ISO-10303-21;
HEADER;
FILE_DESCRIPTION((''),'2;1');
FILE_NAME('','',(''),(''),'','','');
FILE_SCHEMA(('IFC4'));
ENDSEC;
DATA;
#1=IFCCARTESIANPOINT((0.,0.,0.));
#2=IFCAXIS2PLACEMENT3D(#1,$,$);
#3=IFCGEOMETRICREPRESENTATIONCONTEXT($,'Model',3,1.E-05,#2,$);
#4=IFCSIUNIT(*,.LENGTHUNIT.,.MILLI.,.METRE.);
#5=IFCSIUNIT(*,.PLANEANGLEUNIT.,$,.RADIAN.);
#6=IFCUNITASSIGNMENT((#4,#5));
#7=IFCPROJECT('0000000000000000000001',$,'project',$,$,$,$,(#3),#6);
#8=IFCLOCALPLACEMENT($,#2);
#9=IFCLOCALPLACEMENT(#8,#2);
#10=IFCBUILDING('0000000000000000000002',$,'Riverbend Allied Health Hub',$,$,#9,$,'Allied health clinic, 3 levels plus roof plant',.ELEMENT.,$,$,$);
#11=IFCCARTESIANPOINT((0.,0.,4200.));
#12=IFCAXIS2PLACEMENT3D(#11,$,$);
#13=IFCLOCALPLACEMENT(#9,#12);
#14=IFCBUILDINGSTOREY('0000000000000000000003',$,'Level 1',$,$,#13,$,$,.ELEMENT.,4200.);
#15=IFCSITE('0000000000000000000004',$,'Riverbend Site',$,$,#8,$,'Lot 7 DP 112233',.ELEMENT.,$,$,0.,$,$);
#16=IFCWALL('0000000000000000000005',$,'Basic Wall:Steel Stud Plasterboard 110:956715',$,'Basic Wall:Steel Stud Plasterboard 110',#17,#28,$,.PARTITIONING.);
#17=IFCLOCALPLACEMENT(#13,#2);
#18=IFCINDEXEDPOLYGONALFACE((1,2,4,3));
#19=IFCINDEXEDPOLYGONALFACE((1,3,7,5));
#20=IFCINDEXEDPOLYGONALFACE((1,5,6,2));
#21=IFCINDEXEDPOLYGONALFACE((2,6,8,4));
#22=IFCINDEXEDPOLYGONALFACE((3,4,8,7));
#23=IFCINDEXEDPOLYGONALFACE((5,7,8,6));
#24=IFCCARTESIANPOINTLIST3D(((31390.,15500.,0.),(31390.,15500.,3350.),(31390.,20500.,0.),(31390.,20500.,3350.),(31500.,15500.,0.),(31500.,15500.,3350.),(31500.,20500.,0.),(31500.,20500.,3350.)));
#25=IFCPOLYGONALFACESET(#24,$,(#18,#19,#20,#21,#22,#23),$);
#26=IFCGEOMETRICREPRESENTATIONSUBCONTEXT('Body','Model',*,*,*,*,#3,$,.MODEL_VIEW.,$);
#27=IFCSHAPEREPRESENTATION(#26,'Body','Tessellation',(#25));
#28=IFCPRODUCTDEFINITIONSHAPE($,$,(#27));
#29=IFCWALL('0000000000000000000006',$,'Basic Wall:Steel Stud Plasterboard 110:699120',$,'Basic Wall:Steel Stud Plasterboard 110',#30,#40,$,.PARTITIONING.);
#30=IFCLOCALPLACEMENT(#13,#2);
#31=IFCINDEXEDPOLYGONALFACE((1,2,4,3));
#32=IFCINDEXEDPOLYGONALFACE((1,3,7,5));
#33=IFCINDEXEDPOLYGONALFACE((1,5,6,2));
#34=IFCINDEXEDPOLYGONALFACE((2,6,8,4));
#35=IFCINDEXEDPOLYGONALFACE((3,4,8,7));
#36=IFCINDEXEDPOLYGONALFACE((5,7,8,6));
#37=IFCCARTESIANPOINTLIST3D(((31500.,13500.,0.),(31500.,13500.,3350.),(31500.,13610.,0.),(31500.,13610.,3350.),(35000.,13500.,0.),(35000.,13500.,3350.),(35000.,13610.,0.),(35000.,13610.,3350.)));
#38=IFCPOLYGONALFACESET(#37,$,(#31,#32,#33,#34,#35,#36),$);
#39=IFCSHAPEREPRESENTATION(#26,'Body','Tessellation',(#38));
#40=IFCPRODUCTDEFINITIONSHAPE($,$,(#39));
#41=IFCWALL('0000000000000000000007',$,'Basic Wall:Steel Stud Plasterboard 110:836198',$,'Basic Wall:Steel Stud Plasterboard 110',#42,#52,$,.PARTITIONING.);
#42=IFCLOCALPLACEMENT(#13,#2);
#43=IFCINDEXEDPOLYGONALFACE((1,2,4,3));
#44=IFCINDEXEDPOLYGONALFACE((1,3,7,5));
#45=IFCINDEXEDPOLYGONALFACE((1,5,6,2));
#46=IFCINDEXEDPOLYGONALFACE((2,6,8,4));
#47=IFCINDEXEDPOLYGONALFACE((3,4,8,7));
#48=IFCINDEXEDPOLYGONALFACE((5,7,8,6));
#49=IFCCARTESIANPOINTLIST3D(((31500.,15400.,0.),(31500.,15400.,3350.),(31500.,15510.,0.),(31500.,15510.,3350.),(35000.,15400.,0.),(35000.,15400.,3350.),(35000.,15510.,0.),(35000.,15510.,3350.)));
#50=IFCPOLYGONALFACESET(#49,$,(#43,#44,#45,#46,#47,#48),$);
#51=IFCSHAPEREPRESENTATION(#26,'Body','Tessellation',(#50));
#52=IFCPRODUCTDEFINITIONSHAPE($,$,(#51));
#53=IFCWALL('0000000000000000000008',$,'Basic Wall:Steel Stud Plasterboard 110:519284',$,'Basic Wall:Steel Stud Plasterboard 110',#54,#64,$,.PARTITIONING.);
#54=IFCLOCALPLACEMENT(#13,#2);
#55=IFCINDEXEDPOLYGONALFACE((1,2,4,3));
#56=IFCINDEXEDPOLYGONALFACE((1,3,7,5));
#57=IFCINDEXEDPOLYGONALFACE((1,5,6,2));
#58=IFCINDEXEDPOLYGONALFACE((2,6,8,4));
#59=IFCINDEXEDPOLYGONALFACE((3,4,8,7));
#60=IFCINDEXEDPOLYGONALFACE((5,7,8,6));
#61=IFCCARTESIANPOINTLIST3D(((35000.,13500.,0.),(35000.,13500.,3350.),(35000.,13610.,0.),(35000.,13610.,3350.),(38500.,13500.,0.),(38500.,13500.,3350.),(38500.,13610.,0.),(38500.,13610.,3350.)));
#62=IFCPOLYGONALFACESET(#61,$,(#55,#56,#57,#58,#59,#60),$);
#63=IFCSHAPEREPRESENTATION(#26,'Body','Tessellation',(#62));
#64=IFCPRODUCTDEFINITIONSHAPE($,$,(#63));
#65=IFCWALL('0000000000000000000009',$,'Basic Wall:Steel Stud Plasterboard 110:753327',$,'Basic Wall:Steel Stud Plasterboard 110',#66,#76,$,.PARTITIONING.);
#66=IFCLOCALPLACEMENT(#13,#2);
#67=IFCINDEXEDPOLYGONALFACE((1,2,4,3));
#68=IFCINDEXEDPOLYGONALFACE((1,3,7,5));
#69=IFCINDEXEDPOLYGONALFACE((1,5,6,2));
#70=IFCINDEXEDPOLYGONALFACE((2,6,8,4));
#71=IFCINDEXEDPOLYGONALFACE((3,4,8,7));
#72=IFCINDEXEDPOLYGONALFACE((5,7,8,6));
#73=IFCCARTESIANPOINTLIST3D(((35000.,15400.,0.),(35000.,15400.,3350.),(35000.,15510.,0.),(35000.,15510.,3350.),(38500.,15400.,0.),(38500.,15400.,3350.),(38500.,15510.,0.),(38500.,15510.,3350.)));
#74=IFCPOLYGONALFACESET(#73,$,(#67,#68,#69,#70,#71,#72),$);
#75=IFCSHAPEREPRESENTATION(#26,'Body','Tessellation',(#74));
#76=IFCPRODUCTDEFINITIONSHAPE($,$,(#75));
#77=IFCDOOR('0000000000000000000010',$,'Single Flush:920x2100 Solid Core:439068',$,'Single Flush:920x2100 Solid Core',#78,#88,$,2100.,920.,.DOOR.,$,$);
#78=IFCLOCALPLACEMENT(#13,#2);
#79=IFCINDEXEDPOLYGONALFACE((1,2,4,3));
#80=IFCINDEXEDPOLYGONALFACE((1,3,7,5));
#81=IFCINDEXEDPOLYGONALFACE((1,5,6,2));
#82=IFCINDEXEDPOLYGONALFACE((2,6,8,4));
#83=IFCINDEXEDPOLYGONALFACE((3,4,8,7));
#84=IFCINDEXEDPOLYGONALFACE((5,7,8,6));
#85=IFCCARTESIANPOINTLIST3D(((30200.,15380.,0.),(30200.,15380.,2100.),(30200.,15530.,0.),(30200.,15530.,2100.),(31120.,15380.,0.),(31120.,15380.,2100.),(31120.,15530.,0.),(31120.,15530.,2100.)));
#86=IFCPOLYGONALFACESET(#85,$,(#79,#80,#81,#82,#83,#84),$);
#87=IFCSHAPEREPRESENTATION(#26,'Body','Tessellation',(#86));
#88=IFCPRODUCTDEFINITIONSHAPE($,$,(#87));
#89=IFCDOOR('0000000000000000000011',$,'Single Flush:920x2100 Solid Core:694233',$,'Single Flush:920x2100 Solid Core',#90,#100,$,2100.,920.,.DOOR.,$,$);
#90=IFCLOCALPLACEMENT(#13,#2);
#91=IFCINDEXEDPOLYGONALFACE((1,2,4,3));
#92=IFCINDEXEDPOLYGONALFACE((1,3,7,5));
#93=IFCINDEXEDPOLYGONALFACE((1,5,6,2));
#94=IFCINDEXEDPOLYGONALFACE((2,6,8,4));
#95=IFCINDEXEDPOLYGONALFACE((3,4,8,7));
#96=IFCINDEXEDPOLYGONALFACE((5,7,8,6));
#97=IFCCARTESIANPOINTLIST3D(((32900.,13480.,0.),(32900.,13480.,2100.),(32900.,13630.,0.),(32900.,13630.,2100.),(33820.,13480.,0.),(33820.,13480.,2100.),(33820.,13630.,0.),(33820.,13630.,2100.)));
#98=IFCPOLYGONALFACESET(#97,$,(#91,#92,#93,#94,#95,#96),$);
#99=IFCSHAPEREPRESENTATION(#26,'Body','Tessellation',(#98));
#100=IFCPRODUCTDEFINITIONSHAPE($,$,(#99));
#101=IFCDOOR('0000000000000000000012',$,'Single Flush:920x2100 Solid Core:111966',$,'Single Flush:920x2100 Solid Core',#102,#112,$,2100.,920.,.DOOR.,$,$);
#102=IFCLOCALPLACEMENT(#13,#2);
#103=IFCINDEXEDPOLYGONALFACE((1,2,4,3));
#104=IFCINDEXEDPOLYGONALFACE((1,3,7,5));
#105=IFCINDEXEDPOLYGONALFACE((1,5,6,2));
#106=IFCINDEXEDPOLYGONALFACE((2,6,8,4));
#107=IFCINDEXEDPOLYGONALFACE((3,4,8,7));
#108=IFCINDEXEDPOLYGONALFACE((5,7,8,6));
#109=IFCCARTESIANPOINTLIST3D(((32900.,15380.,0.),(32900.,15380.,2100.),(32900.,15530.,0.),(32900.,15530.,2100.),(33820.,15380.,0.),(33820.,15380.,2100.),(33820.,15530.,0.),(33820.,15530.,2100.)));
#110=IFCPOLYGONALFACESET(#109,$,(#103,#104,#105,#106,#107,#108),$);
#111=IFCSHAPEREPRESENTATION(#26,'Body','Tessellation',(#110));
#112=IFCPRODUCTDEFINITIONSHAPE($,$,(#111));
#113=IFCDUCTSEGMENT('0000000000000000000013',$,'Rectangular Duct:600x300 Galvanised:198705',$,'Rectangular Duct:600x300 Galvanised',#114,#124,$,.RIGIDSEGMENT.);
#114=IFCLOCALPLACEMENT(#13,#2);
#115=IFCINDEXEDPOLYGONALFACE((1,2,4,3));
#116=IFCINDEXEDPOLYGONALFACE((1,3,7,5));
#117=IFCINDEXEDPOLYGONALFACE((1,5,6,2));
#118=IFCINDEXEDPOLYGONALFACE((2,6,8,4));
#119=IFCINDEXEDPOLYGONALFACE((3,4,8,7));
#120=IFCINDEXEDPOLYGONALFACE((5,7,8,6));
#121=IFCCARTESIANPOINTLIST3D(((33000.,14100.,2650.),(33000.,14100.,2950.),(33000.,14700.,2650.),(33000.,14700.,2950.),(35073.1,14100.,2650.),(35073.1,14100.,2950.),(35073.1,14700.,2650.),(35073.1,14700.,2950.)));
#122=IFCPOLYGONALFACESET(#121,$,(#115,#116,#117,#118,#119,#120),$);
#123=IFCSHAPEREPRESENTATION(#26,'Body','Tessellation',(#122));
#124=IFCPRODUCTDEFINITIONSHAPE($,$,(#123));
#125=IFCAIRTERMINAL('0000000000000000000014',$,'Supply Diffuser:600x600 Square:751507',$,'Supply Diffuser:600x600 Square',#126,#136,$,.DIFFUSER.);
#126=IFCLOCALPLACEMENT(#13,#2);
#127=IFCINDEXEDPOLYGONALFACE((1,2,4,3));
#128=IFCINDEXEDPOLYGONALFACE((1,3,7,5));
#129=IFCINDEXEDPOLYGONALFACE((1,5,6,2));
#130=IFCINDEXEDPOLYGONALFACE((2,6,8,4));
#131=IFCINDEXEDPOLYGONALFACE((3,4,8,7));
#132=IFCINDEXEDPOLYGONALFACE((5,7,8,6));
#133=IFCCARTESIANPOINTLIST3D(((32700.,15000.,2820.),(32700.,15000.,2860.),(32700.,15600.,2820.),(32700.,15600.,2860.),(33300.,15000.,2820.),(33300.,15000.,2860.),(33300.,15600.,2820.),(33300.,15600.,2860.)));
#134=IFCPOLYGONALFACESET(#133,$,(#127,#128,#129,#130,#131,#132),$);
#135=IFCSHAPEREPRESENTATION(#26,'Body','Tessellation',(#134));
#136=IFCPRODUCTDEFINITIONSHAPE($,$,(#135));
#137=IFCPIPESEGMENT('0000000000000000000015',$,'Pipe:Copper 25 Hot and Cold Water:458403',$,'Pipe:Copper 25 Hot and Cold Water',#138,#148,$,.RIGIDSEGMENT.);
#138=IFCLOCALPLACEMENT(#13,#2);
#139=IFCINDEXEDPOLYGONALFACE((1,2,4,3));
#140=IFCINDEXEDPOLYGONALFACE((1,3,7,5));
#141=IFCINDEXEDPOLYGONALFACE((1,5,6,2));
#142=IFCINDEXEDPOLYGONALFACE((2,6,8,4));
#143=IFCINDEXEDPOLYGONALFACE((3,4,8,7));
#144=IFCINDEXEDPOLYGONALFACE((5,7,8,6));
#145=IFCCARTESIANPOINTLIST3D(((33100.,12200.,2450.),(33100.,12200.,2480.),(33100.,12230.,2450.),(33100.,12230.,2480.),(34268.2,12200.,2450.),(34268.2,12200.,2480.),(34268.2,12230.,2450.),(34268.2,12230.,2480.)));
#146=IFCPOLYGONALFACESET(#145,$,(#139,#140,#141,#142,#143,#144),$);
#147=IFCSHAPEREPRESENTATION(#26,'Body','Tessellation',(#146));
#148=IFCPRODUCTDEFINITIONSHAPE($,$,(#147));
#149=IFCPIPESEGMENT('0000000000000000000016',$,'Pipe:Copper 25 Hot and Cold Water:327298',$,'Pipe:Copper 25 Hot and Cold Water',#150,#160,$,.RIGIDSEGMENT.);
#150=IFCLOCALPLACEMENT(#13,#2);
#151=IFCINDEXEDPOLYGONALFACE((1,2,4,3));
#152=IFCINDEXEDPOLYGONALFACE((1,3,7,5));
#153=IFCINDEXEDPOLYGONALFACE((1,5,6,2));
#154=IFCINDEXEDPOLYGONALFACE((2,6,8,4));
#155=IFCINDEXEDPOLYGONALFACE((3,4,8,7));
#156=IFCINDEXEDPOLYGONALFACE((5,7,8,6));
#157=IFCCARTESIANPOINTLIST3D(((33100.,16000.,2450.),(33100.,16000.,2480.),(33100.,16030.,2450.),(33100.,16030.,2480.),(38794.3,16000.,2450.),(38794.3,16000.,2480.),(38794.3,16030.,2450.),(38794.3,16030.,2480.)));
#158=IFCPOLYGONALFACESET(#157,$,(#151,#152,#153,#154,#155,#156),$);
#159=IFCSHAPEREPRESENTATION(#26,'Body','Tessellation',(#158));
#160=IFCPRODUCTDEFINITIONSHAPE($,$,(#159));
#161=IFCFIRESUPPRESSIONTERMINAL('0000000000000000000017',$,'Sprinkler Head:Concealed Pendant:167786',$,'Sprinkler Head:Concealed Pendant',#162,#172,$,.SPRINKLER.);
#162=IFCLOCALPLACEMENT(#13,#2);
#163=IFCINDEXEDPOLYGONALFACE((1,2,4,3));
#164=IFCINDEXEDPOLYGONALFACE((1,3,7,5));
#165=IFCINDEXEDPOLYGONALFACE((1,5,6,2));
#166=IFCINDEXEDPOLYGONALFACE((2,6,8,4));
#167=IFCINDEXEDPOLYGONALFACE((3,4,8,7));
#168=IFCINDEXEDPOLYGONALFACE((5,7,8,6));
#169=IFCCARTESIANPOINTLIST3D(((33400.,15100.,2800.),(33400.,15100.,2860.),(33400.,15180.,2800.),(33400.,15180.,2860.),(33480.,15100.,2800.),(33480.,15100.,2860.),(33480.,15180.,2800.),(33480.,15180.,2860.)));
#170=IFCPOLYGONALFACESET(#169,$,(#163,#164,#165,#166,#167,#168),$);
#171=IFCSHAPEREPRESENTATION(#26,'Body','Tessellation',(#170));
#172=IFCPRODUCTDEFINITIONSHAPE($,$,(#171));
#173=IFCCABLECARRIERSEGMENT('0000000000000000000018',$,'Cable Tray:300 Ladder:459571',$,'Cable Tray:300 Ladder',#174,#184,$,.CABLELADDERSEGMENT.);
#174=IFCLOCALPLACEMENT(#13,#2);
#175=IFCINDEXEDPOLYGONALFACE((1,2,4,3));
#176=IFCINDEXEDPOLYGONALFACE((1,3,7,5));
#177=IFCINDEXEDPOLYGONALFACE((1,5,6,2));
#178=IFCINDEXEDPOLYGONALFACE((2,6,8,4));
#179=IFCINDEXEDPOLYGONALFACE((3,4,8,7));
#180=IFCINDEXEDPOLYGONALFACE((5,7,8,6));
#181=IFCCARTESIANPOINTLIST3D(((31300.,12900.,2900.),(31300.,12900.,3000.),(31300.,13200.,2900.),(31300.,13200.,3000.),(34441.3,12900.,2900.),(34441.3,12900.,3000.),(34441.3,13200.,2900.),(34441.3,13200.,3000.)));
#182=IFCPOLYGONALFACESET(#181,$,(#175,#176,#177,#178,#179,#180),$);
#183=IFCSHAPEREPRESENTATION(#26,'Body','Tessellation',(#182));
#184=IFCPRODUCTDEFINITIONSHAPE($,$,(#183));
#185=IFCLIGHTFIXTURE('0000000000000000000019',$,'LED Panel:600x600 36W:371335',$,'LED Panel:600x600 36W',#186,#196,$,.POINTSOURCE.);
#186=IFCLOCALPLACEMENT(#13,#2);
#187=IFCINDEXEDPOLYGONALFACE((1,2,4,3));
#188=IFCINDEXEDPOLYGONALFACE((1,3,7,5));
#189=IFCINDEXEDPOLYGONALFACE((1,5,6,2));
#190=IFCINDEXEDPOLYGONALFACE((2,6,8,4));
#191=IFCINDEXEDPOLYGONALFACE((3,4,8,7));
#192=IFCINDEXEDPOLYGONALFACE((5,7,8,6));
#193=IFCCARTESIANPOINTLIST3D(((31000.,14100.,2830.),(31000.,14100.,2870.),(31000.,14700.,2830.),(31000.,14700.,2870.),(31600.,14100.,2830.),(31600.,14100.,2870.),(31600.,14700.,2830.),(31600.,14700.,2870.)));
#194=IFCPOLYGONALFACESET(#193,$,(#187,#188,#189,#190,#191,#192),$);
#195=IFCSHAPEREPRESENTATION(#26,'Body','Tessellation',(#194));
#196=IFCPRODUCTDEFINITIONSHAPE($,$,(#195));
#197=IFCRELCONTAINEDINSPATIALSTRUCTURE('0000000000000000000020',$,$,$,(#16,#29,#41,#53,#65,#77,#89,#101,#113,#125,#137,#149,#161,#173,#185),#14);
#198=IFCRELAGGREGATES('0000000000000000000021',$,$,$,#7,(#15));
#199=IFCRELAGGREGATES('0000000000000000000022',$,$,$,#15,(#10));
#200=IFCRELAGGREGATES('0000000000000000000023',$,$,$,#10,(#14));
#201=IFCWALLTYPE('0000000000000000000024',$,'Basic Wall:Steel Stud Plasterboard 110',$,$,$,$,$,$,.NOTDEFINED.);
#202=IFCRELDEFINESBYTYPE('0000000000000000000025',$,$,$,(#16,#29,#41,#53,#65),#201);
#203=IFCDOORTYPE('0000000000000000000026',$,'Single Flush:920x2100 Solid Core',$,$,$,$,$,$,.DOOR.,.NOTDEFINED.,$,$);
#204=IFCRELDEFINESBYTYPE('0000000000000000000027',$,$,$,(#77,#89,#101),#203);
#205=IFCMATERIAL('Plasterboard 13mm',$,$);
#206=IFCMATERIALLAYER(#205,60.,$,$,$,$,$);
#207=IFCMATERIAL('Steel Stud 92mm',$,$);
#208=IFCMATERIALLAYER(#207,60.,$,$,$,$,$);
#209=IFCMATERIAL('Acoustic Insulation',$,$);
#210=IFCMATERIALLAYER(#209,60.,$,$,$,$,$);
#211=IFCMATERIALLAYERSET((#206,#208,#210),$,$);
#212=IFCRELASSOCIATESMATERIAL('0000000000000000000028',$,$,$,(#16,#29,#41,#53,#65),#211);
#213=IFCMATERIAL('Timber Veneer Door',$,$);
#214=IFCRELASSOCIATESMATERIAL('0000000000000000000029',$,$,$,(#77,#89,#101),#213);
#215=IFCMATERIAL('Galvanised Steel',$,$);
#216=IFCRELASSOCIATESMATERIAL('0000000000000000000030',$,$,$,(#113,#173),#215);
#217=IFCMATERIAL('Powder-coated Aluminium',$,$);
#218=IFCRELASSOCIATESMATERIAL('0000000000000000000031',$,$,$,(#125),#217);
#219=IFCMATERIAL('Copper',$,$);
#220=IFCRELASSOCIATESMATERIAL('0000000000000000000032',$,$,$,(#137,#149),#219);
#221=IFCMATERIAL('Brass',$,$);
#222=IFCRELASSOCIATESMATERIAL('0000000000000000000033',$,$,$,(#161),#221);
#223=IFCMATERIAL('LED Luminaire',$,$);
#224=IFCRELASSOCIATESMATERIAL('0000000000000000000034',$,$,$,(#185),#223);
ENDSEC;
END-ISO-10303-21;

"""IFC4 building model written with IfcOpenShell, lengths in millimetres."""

from ifc_helpers import new_model, si_unit, frame, frame_2d, origin, place, context, subcontext, project, spatial, rectangle, extrude, material, layer, layer_set, layer_usage, type_object, element, save


model = new_model("IFC4")

# Units and contexts
model_context = context("Model", 3, precision=1e-05, world=origin())
body_context = subcontext(model_context, "Body", "Model", "MODEL_VIEW")
ifc_project = project(units=[si_unit("LENGTHUNIT", "METRE", prefix="MILLI"), si_unit("PLANEANGLEUNIT", "RADIAN")], contexts=[model_context])

# Site, building, storey
site_placement = place(None, origin())
site = spatial("IfcSite", under=ifc_project, at=site_placement, Name="Riverbend Site", LongName="Lot 7 DP 112233", CompositionType="ELEMENT", RefElevation=0.0)
building_placement = place(site_placement, origin())
building = spatial("IfcBuilding", under=site, at=building_placement, Name="Riverbend Allied Health Hub", LongName="Allied health clinic, 3 levels plus roof plant", CompositionType="ELEMENT")
storey_placement = place(building_placement, frame((0.0, 0.0, 4200.0)))
storey = spatial("IfcBuildingStorey", under=building, at=storey_placement, Name="Level 1", CompositionType="ELEMENT", Elevation=4200.0)

# Walls
ifc_material_1 = material(Name="Plasterboard 13mm")
ifc_layer_1 = layer(ifc_material_1, 60.0)
ifc_material_2 = material(Name="Steel Stud 92mm")
ifc_layer_2 = layer(ifc_material_2, 60.0)
ifc_material_3 = material(Name="Acoustic Insulation")
ifc_layer_3 = layer(ifc_material_3, 60.0)
ifc_layer_set = layer_set([ifc_layer_1, ifc_layer_2, ifc_layer_3])
ifc_layer_usage = layer_usage(ifc_layer_set, "AXIS2", "POSITIVE", 0.0)
wall_type = type_object("IfcWallType", Name="Basic Wall:Steel Stud Plasterboard 110", PredefinedType="NOTDEFINED")
wall_placement = place(storey_placement, frame((31500.0, 15500.0, 0.0), z_axis=(0.0, 0.0, 1.0), x_axis=(0.0, 1.0, 0.0)))
element("IfcWall", 1, at=wall_placement, inside=storey, type_object=wall_type, material=ifc_layer_usage, Name="Basic Wall:Steel Stud Plasterboard 110:956715", ObjectType="Basic Wall:Steel Stud Plasterboard 110", PredefinedType="PARTITIONING", context=body_context, shape_type="SweptSolid", body=[
    extrude(rectangle(XDim=5000.0, YDim=110.0, at=frame_2d((2500.0, 55.0))), origin(), (0.0, 0.0, 1.0), 3350.0),
])
for number, where, name in (
    (2, (31500.0, 13500.0, 0.0), "Basic Wall:Steel Stud Plasterboard 110:699120"),
    (3, (31500.0, 15400.0, 0.0), "Basic Wall:Steel Stud Plasterboard 110:836198"),
    (4, (35000.0, 13500.0, 0.0), "Basic Wall:Steel Stud Plasterboard 110:519284"),
    (5, (35000.0, 15400.0, 0.0), "Basic Wall:Steel Stud Plasterboard 110:753327"),
):
    element("IfcWall", number, at=place(storey_placement, frame(where)), inside=storey, type_object=wall_type, material=ifc_layer_usage, Name=name, ObjectType="Basic Wall:Steel Stud Plasterboard 110", PredefinedType="PARTITIONING", context=body_context, shape_type="SweptSolid", body=[
        extrude(rectangle(XDim=3500.0, YDim=110.0, at=frame_2d((1750.0, 55.0))), origin(), (0.0, 0.0, 1.0), 3350.0),
    ])

# Doors
ifc_material_4 = material(Name="Timber Veneer Door")
door_type = type_object("IfcDoorType", Name="Single Flush:920x2100 Solid Core", OperationType="NOTDEFINED", PredefinedType="DOOR")
for number, where, name in (
    (6, (30200.0, 15380.0, 0.0), "Single Flush:920x2100 Solid Core:439068"),
    (7, (32900.0, 13480.0, 0.0), "Single Flush:920x2100 Solid Core:694233"),
    (8, (32900.0, 15380.0, 0.0), "Single Flush:920x2100 Solid Core:111966"),
):
    element("IfcDoor", number, at=place(storey_placement, frame(where)), inside=storey, type_object=door_type, material=ifc_material_4, Name=name, ObjectType="Single Flush:920x2100 Solid Core", OverallHeight=2100.0, OverallWidth=920.0, PredefinedType="DOOR", context=body_context, shape_type="SweptSolid", body=[
        extrude(rectangle(XDim=920.0, YDim=150.0, at=frame_2d((460.0, 75.0))), origin(), (0.0, 0.0, 1.0), 2100.0),
    ])

# Duct segment
ifc_material_5 = material(Name="Galvanised Steel")
duct_segment_placement = place(storey_placement, frame((33000.0, 14100.0, 2650.0)))
element("IfcDuctSegment", 9, at=duct_segment_placement, inside=storey, material=ifc_material_5, Name="Rectangular Duct:600x300 Galvanised:198705", ObjectType="Rectangular Duct:600x300 Galvanised", PredefinedType="RIGIDSEGMENT", context=body_context, shape_type="SweptSolid", body=[
    extrude(rectangle(XDim=2073.1, YDim=600.0, at=frame_2d((1036.5, 300.0))), origin(), (0.0, 0.0, 1.0), 300.0),
])

# Air terminal
ifc_material_6 = material(Name="Powder-coated Aluminium")
air_terminal_placement = place(storey_placement, frame((32700.0, 15000.0, 2820.0)))
element("IfcAirTerminal", 10, at=air_terminal_placement, inside=storey, material=ifc_material_6, Name="Supply Diffuser:600x600 Square:751507", ObjectType="Supply Diffuser:600x600 Square", PredefinedType="DIFFUSER", context=body_context, shape_type="SweptSolid", body=[
    extrude(rectangle(XDim=600.0, YDim=600.0, at=frame_2d((300.0, 300.0))), origin(), (0.0, 0.0, 1.0), 40.0),
])

# Pipe segments
ifc_material_7 = material(Name="Copper")
pipe_segment_1_placement = place(storey_placement, frame((33100.0, 12200.0, 2450.0)))
element("IfcPipeSegment", 11, at=pipe_segment_1_placement, inside=storey, material=ifc_material_7, Name="Pipe:Copper 25 Hot and Cold Water:458403", ObjectType="Pipe:Copper 25 Hot and Cold Water", PredefinedType="RIGIDSEGMENT", context=body_context, shape_type="SweptSolid", body=[
    extrude(rectangle(XDim=1168.2, YDim=30.0, at=frame_2d((584.1, 15.0))), origin(), (0.0, 0.0, 1.0), 30.0),
])
pipe_segment_2_placement = place(storey_placement, frame((33100.0, 16000.0, 2450.0)))
element("IfcPipeSegment", 12, at=pipe_segment_2_placement, inside=storey, material=ifc_material_7, Name="Pipe:Copper 25 Hot and Cold Water:327298", ObjectType="Pipe:Copper 25 Hot and Cold Water", PredefinedType="RIGIDSEGMENT", context=body_context, shape_type="SweptSolid", body=[
    extrude(rectangle(XDim=5694.3, YDim=30.0, at=frame_2d((2847.2, 15.0))), origin(), (0.0, 0.0, 1.0), 30.0),
])

# Fire suppression terminal
ifc_material_8 = material(Name="Brass")
fire_suppression_terminal_placement = place(storey_placement, frame((33400.0, 15100.0, 2800.0)))
element("IfcFireSuppressionTerminal", 13, at=fire_suppression_terminal_placement, inside=storey, material=ifc_material_8, Name="Sprinkler Head:Concealed Pendant:167786", ObjectType="Sprinkler Head:Concealed Pendant", PredefinedType="SPRINKLER", context=body_context, shape_type="SweptSolid", body=[
    extrude(rectangle(XDim=80.0, YDim=80.0, at=frame_2d((40.0, 40.0))), origin(), (0.0, 0.0, 1.0), 60.0),
])

# Cable carrier segment
cable_carrier_segment_placement = place(storey_placement, frame((31300.0, 12900.0, 2900.0)))
element("IfcCableCarrierSegment", 14, at=cable_carrier_segment_placement, inside=storey, material=ifc_material_5, Name="Cable Tray:300 Ladder:459571", ObjectType="Cable Tray:300 Ladder", PredefinedType="CABLELADDERSEGMENT", context=body_context, shape_type="SweptSolid", body=[
    extrude(rectangle(XDim=3141.3, YDim=300.0, at=frame_2d((1570.7, 150.0))), origin(), (0.0, 0.0, 1.0), 100.0),
])

# Light fixture
ifc_material_9 = material(Name="LED Luminaire")
for number, where, name in (
    (15, (31000.0, 14100.0, 2830.0), "LED Panel:600x600 36W:371335"),
):
    element("IfcLightFixture", number, at=place(storey_placement, frame(where)), inside=storey, material=ifc_material_9, Name=name, ObjectType="LED Panel:600x600 36W", PredefinedType="POINTSOURCE", context=body_context, shape_type="SweptSolid", body=[
        extrude(rectangle(XDim=600.0, YDim=600.0, at=frame_2d((300.0, 300.0))), origin(), (0.0, 0.0, 1.0), 40.0),
    ])

save(model, "model.ifc")
